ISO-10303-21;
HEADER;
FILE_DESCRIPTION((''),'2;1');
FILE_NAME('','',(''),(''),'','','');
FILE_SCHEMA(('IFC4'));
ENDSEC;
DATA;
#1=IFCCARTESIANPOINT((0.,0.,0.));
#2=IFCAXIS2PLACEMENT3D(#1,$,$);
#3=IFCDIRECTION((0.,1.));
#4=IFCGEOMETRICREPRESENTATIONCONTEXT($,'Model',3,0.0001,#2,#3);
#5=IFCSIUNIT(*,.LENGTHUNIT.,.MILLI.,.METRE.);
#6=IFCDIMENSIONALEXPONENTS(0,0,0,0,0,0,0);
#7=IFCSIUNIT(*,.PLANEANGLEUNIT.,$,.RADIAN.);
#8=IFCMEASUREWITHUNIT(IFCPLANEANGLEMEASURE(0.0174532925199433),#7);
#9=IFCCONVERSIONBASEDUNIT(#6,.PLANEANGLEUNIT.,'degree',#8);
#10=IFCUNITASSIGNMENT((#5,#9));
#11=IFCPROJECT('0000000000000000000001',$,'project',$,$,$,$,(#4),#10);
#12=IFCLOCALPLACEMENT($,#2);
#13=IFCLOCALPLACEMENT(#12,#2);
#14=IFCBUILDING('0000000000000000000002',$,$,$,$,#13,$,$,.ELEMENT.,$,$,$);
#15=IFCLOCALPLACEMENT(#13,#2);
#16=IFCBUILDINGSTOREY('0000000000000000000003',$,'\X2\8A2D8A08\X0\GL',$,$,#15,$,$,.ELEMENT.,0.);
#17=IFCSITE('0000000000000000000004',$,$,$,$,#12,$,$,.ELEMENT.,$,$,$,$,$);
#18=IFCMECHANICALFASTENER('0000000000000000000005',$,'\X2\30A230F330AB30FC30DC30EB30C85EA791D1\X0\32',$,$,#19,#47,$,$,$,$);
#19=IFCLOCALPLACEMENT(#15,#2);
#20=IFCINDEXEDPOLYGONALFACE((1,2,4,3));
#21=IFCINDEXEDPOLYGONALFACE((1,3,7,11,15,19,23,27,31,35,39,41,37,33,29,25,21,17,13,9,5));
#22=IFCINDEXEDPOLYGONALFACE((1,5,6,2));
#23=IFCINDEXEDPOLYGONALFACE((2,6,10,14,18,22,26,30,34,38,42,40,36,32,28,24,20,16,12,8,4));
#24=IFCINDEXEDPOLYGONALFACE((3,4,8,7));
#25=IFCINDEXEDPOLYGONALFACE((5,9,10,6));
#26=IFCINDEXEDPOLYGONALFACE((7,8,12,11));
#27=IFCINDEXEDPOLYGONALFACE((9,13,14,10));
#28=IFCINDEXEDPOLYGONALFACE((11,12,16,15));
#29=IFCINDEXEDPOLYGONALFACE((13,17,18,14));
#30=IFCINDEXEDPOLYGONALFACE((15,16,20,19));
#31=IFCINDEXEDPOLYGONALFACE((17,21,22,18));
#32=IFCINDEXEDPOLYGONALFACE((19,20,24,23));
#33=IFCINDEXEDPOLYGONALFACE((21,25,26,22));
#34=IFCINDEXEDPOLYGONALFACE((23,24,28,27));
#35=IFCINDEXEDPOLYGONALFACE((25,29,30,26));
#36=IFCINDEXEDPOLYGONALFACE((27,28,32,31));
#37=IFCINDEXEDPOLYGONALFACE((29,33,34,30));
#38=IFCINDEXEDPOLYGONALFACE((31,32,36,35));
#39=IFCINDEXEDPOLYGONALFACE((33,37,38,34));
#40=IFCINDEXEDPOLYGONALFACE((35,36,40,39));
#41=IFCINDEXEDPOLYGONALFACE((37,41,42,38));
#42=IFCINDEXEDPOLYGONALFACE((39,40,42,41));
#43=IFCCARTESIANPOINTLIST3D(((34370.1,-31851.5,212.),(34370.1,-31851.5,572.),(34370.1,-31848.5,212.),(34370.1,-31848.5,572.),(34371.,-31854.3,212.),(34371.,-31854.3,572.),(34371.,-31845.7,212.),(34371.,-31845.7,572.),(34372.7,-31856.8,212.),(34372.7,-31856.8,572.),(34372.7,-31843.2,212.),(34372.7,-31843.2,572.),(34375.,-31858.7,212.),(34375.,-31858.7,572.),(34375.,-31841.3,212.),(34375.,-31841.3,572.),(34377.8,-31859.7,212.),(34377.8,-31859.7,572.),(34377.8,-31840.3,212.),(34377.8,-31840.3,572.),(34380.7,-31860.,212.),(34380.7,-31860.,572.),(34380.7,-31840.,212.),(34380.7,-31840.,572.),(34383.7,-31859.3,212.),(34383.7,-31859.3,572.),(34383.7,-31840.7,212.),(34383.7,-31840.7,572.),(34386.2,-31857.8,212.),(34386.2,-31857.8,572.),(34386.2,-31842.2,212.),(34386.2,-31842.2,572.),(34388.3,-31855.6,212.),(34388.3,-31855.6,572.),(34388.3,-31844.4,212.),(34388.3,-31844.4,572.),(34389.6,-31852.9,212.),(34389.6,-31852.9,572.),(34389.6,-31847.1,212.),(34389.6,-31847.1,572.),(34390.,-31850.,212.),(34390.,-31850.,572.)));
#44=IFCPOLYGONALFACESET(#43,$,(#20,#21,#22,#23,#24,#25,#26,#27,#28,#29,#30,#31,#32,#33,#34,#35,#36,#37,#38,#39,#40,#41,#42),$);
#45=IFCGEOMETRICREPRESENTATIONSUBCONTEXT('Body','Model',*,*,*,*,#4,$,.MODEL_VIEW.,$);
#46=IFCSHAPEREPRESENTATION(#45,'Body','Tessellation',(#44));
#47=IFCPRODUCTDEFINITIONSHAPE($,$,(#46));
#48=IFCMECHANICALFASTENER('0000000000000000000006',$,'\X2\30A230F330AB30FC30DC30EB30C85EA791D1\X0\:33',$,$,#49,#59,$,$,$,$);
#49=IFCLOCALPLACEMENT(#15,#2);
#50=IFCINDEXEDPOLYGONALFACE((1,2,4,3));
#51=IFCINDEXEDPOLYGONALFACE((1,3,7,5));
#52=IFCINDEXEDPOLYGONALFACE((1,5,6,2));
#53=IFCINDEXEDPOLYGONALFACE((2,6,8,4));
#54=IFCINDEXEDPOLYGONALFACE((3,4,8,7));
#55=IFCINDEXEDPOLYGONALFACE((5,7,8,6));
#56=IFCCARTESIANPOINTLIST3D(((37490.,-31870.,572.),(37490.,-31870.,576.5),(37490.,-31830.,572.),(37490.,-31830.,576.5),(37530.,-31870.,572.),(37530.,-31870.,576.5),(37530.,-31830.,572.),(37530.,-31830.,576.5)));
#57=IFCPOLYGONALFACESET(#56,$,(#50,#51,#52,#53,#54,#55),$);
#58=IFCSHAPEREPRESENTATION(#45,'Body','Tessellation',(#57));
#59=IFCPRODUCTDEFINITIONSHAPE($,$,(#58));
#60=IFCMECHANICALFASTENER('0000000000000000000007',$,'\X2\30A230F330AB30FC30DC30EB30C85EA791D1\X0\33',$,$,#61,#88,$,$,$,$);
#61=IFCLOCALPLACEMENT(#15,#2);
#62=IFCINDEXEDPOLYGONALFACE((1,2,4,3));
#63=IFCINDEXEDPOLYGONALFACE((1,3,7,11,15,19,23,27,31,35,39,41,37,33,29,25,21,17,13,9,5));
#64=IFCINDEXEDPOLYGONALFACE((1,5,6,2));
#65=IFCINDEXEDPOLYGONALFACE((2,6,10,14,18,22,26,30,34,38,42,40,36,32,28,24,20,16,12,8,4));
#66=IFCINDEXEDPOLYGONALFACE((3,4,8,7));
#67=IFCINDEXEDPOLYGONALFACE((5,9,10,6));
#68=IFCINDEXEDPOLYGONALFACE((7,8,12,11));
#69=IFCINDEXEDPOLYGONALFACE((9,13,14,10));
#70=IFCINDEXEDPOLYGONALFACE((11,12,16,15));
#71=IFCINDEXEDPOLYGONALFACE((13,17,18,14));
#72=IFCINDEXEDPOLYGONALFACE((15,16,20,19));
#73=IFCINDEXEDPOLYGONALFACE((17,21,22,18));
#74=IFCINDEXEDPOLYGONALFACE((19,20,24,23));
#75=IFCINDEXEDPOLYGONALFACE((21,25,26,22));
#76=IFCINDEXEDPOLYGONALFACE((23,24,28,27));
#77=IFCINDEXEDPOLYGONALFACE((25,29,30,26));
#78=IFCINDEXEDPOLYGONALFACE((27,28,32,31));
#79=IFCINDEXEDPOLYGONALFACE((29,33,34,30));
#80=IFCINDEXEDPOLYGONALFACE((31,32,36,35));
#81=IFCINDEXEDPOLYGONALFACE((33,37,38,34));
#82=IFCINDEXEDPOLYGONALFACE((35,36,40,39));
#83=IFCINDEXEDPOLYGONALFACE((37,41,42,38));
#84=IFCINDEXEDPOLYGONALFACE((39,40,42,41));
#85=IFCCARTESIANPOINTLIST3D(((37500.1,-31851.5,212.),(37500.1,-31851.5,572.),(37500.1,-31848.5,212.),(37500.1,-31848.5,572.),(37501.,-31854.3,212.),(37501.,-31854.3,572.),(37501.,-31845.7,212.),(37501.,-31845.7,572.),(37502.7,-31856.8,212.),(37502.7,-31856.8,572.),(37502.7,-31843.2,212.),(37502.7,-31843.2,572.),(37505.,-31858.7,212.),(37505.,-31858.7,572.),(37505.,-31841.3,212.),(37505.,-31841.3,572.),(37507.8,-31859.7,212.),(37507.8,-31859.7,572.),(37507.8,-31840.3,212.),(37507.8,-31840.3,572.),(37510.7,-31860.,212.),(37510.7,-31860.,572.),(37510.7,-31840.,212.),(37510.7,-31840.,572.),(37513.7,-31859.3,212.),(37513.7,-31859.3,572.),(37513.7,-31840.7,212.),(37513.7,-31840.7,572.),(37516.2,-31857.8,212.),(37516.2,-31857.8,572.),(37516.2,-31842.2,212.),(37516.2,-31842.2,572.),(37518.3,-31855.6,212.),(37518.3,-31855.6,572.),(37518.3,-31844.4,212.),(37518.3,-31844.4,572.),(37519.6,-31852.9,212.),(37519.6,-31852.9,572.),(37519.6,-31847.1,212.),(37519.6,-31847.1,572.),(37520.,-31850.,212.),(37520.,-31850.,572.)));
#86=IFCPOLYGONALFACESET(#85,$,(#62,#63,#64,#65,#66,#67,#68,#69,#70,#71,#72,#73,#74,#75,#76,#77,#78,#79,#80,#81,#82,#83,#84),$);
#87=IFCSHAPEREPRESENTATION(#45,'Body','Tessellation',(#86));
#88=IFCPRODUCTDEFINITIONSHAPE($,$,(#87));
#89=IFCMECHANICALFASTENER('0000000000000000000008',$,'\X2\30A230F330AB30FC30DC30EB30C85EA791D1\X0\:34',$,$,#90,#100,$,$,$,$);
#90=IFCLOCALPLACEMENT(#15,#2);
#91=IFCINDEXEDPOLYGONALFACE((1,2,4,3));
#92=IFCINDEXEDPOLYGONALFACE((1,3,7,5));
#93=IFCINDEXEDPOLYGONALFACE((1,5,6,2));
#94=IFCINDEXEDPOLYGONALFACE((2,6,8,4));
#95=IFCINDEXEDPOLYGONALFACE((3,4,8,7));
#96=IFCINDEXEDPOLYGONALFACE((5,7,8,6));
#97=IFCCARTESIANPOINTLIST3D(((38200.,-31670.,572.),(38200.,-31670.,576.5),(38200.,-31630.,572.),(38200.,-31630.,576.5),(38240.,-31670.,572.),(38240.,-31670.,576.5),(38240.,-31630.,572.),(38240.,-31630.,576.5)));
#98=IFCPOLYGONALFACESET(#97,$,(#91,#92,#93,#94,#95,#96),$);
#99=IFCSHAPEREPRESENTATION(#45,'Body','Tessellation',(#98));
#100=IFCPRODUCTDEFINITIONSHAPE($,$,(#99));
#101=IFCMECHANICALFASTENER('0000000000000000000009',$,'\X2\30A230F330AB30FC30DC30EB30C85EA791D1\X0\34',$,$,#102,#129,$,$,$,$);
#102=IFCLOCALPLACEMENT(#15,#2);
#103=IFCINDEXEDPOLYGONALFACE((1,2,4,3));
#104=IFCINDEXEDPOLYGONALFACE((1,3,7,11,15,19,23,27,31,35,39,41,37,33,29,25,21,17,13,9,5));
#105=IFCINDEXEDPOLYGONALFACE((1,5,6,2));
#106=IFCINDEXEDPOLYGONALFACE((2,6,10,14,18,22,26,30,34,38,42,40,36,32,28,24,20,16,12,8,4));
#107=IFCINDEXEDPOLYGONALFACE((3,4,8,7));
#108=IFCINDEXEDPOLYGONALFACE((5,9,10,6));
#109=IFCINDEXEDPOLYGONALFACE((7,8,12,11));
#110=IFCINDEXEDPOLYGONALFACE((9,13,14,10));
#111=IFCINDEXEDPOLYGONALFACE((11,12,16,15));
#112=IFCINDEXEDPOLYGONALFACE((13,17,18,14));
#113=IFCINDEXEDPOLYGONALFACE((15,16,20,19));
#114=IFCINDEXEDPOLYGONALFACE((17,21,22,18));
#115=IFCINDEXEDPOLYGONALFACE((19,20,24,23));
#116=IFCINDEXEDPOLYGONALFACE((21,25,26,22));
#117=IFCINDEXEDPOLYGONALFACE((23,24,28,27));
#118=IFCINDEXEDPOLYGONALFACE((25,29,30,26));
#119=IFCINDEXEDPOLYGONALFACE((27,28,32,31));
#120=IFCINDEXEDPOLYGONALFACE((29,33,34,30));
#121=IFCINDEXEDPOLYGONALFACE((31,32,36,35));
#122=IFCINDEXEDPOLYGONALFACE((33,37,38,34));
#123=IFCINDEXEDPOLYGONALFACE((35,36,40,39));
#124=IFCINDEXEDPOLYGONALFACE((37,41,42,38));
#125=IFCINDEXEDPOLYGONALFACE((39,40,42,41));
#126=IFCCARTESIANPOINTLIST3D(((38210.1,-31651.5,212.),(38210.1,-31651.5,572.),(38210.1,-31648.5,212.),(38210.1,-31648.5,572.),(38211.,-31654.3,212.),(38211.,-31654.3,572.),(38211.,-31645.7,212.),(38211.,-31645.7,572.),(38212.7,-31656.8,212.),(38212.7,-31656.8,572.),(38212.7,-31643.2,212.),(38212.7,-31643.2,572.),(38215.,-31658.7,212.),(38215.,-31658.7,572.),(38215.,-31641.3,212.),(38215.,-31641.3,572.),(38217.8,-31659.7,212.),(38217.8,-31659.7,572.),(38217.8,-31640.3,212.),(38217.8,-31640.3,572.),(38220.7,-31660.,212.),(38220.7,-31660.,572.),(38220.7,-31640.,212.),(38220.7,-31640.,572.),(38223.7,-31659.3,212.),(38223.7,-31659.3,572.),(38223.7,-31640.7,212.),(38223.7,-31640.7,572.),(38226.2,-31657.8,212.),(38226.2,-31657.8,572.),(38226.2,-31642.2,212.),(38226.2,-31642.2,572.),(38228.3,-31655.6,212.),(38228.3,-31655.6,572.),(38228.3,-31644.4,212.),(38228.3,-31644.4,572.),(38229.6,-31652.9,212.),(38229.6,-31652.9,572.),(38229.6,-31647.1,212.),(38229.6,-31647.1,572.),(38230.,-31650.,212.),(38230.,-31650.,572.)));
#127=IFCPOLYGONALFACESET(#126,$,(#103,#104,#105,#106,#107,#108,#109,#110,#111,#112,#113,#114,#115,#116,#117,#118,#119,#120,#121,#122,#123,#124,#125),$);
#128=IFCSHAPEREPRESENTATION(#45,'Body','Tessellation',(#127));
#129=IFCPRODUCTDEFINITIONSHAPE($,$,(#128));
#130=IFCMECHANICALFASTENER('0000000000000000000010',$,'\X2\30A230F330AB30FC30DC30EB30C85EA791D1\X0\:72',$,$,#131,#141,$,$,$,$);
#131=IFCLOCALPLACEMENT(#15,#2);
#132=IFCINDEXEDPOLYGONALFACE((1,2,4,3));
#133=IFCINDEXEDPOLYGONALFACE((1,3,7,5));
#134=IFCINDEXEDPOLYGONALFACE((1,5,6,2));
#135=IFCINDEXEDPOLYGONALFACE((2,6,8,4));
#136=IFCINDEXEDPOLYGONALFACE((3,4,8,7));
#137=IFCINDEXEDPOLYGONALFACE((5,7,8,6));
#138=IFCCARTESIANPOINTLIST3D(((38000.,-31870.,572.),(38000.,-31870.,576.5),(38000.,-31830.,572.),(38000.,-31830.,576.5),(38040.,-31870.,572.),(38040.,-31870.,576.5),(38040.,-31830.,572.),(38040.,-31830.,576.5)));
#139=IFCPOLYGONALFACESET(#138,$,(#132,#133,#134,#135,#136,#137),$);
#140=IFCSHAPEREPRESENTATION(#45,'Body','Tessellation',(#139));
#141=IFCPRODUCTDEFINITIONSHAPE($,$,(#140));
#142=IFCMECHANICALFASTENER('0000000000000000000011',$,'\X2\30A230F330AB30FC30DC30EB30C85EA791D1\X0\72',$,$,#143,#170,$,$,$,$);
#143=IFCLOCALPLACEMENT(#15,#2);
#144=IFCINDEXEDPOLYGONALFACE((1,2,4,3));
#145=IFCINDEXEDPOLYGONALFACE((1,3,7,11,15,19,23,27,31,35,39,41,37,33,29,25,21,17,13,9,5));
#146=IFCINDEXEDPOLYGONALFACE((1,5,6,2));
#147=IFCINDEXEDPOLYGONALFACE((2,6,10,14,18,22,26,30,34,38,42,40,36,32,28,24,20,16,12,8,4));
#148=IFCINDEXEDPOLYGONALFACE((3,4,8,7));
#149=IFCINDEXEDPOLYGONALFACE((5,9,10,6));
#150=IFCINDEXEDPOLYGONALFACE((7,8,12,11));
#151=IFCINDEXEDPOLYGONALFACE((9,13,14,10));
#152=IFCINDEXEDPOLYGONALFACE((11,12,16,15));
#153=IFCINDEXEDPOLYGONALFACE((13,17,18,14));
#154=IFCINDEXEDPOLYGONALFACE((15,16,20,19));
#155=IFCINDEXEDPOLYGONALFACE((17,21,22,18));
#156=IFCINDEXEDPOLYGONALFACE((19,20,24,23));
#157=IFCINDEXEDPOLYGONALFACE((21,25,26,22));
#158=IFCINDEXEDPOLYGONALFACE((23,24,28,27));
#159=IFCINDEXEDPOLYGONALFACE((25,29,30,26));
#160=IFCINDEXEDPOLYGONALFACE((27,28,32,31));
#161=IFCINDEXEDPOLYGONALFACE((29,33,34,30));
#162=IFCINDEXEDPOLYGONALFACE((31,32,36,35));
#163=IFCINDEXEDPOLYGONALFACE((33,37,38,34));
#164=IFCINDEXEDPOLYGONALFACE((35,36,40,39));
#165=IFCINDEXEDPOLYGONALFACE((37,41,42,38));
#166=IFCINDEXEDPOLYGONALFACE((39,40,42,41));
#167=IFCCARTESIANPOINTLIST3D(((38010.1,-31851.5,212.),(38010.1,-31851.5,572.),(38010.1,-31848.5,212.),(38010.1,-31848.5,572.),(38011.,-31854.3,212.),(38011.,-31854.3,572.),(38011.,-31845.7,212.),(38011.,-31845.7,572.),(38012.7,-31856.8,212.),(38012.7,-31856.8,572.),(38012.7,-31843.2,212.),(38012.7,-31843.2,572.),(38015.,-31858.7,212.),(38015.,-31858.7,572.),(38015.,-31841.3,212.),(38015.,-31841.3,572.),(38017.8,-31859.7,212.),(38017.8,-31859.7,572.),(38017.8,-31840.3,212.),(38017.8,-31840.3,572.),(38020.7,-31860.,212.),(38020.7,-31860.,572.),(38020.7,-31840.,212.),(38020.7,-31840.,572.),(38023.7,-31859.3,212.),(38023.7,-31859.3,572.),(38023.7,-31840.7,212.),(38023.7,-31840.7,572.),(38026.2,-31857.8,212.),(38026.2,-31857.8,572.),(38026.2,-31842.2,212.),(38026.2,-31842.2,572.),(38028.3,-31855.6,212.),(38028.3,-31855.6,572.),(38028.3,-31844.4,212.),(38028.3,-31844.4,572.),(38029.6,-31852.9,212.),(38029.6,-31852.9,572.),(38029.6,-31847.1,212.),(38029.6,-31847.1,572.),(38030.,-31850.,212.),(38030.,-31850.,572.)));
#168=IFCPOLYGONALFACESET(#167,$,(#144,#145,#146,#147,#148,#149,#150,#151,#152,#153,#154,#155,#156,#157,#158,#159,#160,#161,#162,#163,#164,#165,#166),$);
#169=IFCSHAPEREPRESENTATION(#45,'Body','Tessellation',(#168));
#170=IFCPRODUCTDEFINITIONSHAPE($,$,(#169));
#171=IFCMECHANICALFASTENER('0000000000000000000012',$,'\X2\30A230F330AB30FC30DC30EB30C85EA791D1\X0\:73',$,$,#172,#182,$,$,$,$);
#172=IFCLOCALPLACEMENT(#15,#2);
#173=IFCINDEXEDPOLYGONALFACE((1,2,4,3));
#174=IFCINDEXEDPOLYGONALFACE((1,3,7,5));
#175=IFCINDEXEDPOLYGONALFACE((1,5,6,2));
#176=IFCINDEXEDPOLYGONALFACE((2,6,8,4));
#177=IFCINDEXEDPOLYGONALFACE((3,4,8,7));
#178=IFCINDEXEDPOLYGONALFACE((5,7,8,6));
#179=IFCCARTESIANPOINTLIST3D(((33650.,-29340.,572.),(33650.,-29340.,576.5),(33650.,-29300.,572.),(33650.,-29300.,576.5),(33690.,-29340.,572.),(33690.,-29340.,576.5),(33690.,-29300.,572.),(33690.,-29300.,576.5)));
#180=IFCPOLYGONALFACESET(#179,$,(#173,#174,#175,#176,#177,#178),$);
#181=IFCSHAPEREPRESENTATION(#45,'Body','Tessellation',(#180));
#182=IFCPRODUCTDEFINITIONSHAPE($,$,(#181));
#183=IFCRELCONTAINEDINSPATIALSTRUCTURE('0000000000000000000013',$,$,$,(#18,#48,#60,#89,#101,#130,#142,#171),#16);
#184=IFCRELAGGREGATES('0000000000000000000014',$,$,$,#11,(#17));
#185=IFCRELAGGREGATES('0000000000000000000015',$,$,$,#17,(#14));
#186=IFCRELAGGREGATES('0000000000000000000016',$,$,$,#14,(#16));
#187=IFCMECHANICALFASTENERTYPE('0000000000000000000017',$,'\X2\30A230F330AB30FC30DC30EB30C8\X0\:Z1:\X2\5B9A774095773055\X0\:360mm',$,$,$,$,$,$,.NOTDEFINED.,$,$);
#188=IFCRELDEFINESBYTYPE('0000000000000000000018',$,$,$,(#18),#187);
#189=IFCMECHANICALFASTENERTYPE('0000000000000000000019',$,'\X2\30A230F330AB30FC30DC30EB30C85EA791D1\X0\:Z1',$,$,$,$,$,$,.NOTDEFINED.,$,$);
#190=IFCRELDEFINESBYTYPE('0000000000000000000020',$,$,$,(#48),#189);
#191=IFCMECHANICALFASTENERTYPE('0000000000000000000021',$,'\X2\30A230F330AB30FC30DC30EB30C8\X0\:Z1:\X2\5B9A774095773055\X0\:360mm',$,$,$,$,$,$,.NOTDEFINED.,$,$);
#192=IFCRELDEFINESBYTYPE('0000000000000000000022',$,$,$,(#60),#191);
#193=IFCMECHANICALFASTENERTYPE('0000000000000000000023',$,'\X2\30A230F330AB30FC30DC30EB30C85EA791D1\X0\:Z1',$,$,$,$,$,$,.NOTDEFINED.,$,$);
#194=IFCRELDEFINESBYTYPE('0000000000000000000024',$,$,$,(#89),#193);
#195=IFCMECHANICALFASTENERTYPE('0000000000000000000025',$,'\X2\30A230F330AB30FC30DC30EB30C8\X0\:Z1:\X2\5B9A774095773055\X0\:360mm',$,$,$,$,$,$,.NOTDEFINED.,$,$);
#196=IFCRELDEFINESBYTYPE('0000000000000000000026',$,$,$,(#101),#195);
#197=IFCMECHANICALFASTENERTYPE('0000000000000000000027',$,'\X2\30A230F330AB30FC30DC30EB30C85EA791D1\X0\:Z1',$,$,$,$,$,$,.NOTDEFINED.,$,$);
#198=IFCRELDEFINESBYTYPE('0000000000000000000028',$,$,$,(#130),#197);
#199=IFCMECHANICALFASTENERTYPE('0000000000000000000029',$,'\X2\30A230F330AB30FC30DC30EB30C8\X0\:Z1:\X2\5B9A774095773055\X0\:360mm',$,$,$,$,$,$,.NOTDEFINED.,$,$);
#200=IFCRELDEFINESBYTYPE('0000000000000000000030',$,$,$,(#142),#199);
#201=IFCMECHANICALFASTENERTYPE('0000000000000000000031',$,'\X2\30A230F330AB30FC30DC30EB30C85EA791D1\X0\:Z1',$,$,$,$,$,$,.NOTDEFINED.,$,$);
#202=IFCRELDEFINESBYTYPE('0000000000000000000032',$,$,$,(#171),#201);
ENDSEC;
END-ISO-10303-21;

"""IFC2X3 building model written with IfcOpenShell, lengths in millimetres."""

from ifc_helpers import new_model, entity, si_unit, converted_unit, direction, frame, origin, origin_with_axes, origin_2d, place, context, subcontext, project, spatial, rectangle, circle, extrude, type_object, element, save


model = new_model("IFC2X3")

# Units and contexts
model_context = context("Model", 3, precision=0.0001, world=origin(), true_north=direction((0.0, 1.0)))
body_context = subcontext(model_context, "Body", "Model", "MODEL_VIEW")
ifc_project = project(units=[si_unit("LENGTHUNIT", "METRE", prefix="MILLI"), converted_unit("PLANEANGLEUNIT", "degree", entity("IfcPlaneAngleMeasure", 0.0174532925199433), si_unit("PLANEANGLEUNIT", "RADIAN"), dimensions=[0, 0, 0, 0, 0, 0, 0])], contexts=[model_context])

# Site, building, storey
site_placement = place(None, origin())
site = spatial("IfcSite", under=ifc_project, at=site_placement, CompositionType="ELEMENT")
building_placement = place(site_placement, origin())
building = spatial("IfcBuilding", under=site, at=building_placement, CompositionType="ELEMENT")
storey_placement = place(building_placement, origin())
storey = spatial("IfcBuildingStorey", under=building, at=storey_placement, Name="設計GL", CompositionType="ELEMENT", Elevation=0.0)

# Mechanical fasteners
mechanical_fastener_type_1 = type_object("IfcMechanicalFastenerType", Name="アンカーボルト:Z1:定着長さ:360mm")
mechanical_fastener_1_placement = place(storey_placement, frame((34380.0, -31850.0, 212.0)))
element("IfcMechanicalFastener", 1, at=mechanical_fastener_1_placement, inside=storey, type_object=mechanical_fastener_type_1, Name="アンカーボルト座金32", context=body_context, shape_type="SweptSolid", body=[
    extrude(circle(Radius=10.0, at=origin_2d()), origin_with_axes(), (0.0, 0.0, 1.0), 360.0),
])
mechanical_fastener_type_2 = type_object("IfcMechanicalFastenerType", Name="アンカーボルト座金:Z1")
mechanical_fastener_2_placement = place(storey_placement, frame((37510.0, -31850.0, 572.0)))
element("IfcMechanicalFastener", 2, at=mechanical_fastener_2_placement, inside=storey, type_object=mechanical_fastener_type_2, Name="アンカーボルト座金:33", context=body_context, shape_type="SweptSolid", body=[
    extrude(rectangle(XDim=40.0, YDim=40.0, at=origin_2d()), origin_with_axes(), (0.0, 0.0, 1.0), 4.5),
])
mechanical_fastener_type_3 = type_object("IfcMechanicalFastenerType", Name="アンカーボルト:Z1:定着長さ:360mm")
mechanical_fastener_3_placement = place(storey_placement, frame((37510.0, -31850.0, 212.0)))
element("IfcMechanicalFastener", 3, at=mechanical_fastener_3_placement, inside=storey, type_object=mechanical_fastener_type_3, Name="アンカーボルト座金33", context=body_context, shape_type="SweptSolid", body=[
    extrude(circle(Radius=10.0, at=origin_2d()), origin_with_axes(), (0.0, 0.0, 1.0), 360.0),
])
mechanical_fastener_type_4 = type_object("IfcMechanicalFastenerType", Name="アンカーボルト座金:Z1")
mechanical_fastener_4_placement = place(storey_placement, frame((38220.0, -31650.0, 572.0)))
element("IfcMechanicalFastener", 4, at=mechanical_fastener_4_placement, inside=storey, type_object=mechanical_fastener_type_4, Name="アンカーボルト座金:34", context=body_context, shape_type="SweptSolid", body=[
    extrude(rectangle(XDim=40.0, YDim=40.0, at=origin_2d()), origin_with_axes(), (0.0, 0.0, 1.0), 4.5),
])
mechanical_fastener_type_5 = type_object("IfcMechanicalFastenerType", Name="アンカーボルト:Z1:定着長さ:360mm")
mechanical_fastener_5_placement = place(storey_placement, frame((38220.0, -31650.0, 212.0)))
element("IfcMechanicalFastener", 5, at=mechanical_fastener_5_placement, inside=storey, type_object=mechanical_fastener_type_5, Name="アンカーボルト座金34", context=body_context, shape_type="SweptSolid", body=[
    extrude(circle(Radius=10.0, at=origin_2d()), origin_with_axes(), (0.0, 0.0, 1.0), 360.0),
])
mechanical_fastener_type_6 = type_object("IfcMechanicalFastenerType", Name="アンカーボルト座金:Z1")
mechanical_fastener_6_placement = place(storey_placement, frame((38020.0, -31850.0, 572.0)))
element("IfcMechanicalFastener", 6, at=mechanical_fastener_6_placement, inside=storey, type_object=mechanical_fastener_type_6, Name="アンカーボルト座金:72", context=body_context, shape_type="SweptSolid", body=[
    extrude(rectangle(XDim=40.0, YDim=40.0, at=origin_2d()), origin_with_axes(), (0.0, 0.0, 1.0), 4.5),
])
mechanical_fastener_type_7 = type_object("IfcMechanicalFastenerType", Name="アンカーボルト:Z1:定着長さ:360mm")
mechanical_fastener_7_placement = place(storey_placement, frame((38020.0, -31850.0, 212.0)))
element("IfcMechanicalFastener", 7, at=mechanical_fastener_7_placement, inside=storey, type_object=mechanical_fastener_type_7, Name="アンカーボルト座金72", context=body_context, shape_type="SweptSolid", body=[
    extrude(circle(Radius=10.0, at=origin_2d()), origin_with_axes(), (0.0, 0.0, 1.0), 360.0),
])
mechanical_fastener_type_8 = type_object("IfcMechanicalFastenerType", Name="アンカーボルト座金:Z1")
mechanical_fastener_8_placement = place(storey_placement, frame((33670.0, -29320.0, 572.0)))
element("IfcMechanicalFastener", 8, at=mechanical_fastener_8_placement, inside=storey, type_object=mechanical_fastener_type_8, Name="アンカーボルト座金:73", context=body_context, shape_type="SweptSolid", body=[
    extrude(rectangle(XDim=40.0, YDim=40.0, at=origin_2d()), origin_with_axes(), (0.0, 0.0, 1.0), 4.5),
])

save(model, "model.ifc")
